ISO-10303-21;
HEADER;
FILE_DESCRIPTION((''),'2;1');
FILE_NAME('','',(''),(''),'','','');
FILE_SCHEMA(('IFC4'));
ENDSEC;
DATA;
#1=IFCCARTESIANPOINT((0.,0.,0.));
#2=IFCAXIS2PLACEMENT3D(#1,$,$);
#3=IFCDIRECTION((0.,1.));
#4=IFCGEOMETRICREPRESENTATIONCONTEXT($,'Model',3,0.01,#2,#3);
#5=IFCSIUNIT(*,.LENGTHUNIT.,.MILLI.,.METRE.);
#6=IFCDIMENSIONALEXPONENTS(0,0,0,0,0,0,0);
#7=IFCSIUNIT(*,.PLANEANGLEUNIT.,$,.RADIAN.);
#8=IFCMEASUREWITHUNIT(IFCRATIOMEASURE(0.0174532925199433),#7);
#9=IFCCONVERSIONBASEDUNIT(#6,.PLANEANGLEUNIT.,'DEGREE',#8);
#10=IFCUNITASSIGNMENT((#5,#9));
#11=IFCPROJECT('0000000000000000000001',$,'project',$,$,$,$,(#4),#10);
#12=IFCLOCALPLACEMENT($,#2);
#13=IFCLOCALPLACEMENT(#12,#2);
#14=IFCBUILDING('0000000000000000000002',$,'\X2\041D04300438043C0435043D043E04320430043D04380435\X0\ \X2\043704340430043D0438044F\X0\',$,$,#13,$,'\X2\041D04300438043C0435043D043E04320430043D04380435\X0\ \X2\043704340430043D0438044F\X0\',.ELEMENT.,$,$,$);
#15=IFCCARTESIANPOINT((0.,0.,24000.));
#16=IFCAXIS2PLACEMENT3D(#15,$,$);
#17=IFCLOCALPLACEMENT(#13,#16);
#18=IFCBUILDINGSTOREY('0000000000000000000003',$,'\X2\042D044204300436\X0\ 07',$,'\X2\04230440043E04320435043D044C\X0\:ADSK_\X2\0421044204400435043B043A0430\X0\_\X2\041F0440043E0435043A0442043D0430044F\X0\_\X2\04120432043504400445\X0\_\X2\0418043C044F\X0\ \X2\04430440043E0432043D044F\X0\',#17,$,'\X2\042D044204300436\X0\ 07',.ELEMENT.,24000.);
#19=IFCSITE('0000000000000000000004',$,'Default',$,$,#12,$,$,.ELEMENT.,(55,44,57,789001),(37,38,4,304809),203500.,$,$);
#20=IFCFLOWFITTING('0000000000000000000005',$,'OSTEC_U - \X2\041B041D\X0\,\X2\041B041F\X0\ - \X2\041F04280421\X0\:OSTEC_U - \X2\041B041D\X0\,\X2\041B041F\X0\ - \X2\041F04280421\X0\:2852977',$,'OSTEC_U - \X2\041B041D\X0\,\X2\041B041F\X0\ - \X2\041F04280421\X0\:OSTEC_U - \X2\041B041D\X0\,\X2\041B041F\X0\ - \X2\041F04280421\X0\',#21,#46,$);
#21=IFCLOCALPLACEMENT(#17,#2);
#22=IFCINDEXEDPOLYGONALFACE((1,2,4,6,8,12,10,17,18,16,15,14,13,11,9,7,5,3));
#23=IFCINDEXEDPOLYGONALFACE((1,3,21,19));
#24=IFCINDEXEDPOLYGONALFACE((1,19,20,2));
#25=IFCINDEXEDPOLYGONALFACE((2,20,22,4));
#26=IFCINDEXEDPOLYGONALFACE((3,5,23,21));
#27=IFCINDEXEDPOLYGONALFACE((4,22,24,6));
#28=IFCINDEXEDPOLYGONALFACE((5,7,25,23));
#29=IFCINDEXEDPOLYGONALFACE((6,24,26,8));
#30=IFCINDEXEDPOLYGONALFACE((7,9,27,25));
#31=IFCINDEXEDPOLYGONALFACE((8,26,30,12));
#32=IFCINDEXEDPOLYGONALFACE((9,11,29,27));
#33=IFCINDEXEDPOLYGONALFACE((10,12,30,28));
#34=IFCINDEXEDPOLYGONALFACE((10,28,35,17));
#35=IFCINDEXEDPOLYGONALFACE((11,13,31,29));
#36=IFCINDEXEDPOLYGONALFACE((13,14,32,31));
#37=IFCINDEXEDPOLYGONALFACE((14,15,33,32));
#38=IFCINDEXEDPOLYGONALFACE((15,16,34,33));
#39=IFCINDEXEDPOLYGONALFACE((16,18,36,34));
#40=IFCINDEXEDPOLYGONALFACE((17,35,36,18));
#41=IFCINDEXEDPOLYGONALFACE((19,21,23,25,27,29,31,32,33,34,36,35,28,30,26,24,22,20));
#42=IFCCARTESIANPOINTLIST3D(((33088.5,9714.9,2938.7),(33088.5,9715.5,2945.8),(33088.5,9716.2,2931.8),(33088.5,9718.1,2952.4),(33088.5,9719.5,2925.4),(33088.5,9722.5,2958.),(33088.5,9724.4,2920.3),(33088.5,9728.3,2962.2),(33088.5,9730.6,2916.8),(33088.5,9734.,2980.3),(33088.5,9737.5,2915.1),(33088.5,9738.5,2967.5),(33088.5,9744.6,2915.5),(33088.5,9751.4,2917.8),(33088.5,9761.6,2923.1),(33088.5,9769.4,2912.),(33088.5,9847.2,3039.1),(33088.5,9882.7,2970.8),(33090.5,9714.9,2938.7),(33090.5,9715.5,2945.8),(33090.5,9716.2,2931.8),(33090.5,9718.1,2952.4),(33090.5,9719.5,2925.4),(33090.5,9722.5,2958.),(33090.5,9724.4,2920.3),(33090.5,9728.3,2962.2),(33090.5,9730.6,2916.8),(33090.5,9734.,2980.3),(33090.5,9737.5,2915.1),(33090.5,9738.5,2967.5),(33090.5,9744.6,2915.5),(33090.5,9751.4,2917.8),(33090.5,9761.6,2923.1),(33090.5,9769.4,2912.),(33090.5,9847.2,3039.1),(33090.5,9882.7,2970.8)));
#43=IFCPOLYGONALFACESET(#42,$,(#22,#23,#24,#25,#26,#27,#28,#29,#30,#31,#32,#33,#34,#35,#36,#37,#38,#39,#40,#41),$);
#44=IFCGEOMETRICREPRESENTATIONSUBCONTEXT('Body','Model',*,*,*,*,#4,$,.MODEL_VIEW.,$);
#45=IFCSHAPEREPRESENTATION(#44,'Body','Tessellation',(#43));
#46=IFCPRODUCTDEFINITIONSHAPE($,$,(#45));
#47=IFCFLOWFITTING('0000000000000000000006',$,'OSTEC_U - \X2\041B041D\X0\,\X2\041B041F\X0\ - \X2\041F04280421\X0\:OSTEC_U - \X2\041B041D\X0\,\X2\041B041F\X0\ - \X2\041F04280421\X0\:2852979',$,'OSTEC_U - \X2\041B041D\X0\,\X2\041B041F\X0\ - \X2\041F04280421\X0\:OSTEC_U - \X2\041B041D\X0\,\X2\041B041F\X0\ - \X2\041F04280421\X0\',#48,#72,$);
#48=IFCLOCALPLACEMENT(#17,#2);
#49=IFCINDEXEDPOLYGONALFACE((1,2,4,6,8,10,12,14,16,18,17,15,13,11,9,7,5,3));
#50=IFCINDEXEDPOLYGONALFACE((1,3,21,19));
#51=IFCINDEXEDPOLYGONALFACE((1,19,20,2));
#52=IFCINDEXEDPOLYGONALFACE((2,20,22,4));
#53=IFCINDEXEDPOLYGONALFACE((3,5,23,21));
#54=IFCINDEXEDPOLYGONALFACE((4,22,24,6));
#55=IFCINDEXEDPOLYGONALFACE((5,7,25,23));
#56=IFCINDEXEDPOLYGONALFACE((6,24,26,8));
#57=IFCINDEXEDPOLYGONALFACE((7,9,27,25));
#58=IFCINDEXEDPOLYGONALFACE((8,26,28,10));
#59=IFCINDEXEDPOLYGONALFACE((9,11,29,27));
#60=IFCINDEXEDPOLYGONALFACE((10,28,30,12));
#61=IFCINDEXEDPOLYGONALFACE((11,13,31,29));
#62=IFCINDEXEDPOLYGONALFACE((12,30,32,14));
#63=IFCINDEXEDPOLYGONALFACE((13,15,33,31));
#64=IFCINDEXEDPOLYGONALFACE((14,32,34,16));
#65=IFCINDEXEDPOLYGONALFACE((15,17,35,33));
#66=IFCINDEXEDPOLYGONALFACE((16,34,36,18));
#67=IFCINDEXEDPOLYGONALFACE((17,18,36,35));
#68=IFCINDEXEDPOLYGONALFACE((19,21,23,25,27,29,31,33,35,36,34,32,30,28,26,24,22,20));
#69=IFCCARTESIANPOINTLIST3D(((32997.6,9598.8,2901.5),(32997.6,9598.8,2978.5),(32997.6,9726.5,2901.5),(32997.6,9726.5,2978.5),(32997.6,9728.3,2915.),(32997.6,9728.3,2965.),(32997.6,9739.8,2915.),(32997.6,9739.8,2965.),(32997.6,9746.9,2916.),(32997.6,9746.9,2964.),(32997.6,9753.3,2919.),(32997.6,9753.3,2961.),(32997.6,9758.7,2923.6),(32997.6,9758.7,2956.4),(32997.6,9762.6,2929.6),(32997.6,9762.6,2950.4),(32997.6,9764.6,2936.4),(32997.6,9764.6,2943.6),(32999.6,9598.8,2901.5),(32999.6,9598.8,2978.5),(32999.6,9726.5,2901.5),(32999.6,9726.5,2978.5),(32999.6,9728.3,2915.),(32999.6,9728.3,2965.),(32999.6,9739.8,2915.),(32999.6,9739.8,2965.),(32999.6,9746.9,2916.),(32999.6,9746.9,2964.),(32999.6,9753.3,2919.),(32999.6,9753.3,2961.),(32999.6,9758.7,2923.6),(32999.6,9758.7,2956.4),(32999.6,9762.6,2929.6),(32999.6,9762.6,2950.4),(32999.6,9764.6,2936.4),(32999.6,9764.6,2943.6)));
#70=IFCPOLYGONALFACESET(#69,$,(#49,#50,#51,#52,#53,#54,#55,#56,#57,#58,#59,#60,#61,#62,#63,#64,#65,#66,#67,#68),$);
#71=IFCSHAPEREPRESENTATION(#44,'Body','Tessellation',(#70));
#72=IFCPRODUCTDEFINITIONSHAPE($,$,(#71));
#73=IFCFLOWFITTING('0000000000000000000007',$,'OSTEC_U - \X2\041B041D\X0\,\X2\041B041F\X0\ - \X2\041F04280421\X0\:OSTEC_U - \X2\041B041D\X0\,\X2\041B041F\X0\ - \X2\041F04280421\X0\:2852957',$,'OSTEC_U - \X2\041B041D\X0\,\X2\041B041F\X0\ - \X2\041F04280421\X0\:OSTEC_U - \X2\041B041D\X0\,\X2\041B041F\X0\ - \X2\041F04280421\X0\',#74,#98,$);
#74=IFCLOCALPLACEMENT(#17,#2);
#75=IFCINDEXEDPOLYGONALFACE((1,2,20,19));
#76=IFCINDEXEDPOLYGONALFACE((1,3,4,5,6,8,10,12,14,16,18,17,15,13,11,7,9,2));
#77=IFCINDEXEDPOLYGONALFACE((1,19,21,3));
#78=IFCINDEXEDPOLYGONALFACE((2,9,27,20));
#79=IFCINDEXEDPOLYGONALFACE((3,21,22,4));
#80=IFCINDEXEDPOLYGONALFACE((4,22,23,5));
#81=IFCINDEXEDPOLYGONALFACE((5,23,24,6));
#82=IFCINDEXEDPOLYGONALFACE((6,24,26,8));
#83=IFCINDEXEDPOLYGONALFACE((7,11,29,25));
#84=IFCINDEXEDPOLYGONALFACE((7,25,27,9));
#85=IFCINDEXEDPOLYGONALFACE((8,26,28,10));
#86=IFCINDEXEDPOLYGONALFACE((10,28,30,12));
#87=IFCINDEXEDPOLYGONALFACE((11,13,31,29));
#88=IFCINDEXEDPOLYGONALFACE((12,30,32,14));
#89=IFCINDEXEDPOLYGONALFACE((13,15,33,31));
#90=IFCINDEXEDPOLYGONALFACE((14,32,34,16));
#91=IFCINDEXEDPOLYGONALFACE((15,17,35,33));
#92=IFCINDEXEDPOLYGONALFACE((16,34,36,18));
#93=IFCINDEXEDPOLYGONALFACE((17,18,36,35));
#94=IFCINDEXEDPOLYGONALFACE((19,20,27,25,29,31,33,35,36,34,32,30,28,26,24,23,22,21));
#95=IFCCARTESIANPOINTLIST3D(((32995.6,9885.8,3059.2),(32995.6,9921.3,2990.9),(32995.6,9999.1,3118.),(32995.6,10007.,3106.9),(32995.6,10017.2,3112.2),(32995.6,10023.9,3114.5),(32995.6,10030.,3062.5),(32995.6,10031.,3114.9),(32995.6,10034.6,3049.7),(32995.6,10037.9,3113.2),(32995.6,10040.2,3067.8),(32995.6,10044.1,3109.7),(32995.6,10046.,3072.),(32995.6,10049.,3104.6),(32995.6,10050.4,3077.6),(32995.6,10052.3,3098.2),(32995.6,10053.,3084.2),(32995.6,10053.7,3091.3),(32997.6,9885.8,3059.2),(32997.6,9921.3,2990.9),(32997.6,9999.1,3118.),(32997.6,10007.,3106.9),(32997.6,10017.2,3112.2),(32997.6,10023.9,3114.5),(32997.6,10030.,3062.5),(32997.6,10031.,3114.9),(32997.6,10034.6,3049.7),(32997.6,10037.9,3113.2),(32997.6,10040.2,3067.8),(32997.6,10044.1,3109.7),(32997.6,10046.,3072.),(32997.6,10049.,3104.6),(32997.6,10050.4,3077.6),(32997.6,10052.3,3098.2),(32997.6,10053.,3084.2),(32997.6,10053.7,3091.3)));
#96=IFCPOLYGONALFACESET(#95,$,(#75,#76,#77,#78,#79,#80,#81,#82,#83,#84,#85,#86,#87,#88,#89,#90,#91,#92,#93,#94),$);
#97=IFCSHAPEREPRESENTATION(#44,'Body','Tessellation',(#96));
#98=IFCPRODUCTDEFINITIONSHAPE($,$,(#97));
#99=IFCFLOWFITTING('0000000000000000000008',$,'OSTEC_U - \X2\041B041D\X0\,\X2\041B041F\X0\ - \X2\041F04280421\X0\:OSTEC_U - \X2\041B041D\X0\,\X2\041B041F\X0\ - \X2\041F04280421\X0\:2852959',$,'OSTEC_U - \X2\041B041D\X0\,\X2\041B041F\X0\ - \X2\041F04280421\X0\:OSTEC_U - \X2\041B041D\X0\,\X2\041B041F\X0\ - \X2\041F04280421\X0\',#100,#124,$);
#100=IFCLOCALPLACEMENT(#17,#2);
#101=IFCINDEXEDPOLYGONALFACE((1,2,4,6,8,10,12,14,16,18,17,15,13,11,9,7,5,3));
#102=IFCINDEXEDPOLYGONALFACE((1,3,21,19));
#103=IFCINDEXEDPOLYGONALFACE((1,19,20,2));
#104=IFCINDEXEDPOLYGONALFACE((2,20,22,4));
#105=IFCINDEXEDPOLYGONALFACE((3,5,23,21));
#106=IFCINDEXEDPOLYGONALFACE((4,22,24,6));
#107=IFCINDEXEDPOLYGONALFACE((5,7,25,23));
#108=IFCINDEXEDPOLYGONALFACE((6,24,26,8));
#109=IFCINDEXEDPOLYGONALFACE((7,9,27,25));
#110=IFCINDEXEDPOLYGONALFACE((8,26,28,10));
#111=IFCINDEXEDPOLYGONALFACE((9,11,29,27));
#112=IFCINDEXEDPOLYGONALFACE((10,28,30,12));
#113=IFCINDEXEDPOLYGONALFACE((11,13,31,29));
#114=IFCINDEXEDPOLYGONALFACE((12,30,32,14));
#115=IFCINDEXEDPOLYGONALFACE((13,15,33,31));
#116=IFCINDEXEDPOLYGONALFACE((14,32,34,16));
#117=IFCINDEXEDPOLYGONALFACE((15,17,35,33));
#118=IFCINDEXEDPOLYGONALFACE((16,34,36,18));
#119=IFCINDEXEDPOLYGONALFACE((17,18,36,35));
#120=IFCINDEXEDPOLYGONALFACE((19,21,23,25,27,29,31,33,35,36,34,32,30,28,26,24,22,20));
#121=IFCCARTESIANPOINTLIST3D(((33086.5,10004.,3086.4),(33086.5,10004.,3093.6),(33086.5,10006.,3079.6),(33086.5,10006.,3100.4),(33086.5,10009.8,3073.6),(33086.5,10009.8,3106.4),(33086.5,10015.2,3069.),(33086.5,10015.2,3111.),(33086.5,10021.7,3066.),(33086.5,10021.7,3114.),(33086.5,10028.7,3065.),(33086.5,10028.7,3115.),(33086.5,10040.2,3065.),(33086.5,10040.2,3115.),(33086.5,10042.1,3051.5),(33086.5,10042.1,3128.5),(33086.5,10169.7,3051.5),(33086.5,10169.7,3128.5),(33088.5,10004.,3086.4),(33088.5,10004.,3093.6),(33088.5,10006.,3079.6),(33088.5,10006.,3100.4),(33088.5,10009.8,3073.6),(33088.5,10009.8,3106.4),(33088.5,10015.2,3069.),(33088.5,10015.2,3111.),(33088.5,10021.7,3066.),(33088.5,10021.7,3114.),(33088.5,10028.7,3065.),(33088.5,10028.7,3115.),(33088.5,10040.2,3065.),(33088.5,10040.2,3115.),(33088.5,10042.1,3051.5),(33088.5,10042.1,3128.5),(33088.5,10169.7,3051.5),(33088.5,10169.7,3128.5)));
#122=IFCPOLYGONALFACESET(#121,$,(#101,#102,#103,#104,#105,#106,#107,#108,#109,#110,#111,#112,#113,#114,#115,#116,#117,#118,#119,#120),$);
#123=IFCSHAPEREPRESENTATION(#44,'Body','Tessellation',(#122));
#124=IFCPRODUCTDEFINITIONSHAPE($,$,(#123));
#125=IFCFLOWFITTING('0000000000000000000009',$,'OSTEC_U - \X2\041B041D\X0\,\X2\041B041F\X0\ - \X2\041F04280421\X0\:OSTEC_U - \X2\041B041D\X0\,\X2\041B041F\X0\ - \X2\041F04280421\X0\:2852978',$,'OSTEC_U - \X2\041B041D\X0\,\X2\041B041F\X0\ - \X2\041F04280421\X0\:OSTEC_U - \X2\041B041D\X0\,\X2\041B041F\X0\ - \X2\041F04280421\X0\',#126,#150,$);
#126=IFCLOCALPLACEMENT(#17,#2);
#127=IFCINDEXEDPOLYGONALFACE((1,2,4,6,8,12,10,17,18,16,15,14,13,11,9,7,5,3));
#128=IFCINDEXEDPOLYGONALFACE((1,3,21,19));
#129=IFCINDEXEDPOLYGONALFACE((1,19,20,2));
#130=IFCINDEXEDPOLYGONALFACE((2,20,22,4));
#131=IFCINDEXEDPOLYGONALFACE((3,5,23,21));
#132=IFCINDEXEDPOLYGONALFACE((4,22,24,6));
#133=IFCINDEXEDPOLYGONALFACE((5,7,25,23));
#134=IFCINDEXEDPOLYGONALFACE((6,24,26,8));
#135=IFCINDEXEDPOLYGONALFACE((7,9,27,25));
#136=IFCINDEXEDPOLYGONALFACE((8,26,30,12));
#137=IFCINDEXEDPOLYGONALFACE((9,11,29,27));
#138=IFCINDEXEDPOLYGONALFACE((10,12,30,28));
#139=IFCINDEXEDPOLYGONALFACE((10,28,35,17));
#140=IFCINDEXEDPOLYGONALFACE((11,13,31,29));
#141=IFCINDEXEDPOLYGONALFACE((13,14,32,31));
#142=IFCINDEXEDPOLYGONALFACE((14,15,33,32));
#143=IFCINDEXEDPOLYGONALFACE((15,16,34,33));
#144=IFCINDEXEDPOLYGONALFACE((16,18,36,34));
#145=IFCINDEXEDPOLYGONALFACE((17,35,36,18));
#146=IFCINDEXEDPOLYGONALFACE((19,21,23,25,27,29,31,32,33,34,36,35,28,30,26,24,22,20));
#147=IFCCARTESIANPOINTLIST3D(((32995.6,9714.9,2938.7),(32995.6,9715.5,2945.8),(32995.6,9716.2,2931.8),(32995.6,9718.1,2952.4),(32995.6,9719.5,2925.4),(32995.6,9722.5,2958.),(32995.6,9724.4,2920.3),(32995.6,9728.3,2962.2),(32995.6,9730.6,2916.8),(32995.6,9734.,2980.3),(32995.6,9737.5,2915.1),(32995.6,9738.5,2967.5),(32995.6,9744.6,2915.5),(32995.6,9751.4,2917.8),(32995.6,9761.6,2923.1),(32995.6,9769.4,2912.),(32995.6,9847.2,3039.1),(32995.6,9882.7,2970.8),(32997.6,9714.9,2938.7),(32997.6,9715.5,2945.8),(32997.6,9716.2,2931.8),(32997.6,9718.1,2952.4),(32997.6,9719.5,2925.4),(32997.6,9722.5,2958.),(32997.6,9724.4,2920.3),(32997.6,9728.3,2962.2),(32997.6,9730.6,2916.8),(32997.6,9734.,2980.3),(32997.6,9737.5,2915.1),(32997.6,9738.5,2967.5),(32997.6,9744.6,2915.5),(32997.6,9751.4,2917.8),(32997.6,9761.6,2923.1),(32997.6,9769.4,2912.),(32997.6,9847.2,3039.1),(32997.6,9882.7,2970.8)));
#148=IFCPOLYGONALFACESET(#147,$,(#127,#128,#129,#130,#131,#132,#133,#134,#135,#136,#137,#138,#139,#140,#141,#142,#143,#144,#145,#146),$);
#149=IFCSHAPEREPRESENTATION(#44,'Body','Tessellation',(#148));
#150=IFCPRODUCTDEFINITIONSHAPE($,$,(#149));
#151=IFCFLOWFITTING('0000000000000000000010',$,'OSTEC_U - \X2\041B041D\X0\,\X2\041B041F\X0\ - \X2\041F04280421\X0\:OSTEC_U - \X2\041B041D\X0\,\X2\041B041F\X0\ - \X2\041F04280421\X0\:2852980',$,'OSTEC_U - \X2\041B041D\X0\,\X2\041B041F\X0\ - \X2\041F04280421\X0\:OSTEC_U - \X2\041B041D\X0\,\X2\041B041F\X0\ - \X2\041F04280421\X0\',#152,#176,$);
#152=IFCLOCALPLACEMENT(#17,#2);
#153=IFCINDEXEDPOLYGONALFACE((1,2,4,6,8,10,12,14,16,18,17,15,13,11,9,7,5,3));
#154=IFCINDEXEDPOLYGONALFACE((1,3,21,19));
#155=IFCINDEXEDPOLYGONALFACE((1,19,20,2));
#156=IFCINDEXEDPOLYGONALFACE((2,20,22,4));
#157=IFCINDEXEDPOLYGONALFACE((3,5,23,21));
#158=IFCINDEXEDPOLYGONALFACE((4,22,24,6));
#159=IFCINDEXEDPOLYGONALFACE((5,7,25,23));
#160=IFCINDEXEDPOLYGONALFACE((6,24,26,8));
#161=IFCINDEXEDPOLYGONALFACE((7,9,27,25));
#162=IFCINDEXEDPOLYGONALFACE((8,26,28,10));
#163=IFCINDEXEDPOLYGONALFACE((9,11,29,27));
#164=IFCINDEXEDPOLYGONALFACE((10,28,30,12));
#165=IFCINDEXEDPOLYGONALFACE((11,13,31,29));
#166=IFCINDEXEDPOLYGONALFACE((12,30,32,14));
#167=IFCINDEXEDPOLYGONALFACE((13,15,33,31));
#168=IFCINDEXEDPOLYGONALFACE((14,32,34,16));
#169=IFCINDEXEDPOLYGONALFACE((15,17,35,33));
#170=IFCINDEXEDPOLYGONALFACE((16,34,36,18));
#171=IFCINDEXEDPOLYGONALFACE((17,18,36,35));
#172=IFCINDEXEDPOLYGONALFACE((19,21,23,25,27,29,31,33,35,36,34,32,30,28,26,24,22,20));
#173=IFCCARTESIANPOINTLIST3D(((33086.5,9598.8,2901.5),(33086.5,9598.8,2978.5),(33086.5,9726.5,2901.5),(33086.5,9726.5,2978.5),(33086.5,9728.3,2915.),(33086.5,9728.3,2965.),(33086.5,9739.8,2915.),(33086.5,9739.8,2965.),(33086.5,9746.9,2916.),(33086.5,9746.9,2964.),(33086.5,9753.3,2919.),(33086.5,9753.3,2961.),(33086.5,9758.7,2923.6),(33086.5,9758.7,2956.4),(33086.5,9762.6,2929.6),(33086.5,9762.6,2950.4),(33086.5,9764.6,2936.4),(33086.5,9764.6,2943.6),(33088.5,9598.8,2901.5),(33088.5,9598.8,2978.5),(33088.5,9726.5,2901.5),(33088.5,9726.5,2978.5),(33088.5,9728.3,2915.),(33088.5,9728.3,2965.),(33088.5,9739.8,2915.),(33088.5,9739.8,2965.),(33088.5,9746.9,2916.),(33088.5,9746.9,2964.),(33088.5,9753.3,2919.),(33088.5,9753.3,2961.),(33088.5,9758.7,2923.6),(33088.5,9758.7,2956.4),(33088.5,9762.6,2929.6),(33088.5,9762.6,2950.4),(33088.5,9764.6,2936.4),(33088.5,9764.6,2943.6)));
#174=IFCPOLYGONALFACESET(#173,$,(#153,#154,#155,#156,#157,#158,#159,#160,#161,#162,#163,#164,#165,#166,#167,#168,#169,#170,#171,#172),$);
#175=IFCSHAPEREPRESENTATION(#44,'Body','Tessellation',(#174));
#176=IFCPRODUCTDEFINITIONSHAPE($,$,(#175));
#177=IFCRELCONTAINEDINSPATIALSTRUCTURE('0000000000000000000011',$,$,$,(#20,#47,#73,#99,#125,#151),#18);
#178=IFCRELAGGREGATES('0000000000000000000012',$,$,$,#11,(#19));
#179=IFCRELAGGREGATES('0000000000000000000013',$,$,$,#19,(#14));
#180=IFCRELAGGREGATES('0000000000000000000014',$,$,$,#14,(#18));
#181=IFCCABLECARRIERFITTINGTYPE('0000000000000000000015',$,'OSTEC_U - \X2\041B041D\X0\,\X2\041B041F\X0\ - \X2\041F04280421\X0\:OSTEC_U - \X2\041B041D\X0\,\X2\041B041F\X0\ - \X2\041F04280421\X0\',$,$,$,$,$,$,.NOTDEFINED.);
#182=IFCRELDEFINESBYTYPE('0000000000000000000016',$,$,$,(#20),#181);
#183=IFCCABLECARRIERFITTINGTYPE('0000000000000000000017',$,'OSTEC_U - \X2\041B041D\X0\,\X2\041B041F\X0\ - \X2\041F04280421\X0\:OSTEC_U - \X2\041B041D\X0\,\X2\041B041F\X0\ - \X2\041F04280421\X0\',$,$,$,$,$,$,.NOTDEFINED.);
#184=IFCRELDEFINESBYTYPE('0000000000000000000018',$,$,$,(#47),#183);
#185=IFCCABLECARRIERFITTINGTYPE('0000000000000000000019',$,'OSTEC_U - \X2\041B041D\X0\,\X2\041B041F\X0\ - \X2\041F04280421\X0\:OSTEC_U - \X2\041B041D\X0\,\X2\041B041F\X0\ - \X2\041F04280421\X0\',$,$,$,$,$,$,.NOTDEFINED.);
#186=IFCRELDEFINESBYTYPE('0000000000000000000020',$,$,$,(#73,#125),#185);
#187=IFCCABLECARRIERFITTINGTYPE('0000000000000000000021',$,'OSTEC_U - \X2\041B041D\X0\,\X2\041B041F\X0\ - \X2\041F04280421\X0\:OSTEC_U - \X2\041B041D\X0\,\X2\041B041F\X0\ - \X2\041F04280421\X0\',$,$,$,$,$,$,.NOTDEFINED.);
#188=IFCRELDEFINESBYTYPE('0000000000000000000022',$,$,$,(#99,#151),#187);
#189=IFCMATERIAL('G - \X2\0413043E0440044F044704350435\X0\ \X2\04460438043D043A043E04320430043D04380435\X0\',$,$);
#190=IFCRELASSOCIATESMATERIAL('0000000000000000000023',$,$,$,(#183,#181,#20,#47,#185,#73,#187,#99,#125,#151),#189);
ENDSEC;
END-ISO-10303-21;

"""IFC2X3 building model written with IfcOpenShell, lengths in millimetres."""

from ifc_helpers import new_model, entity, si_unit, converted_unit, direction, frame, frame_2d, origin, place, context, subcontext, project, spatial, polyline, circle_curve, parameter, trimmed, segment, composite_curve, outline, extrude, source, transform, mapped, material, type_object, type_shapes, element, save


model = new_model("IFC2X3")

# Units and contexts
model_context = context("Model", 3, precision=0.01, world=origin(), true_north=direction((0.0, 1.0)))
body_context = subcontext(model_context, "Body", "Model", "MODEL_VIEW")
ifc_project = project(units=[si_unit("LENGTHUNIT", "METRE", prefix="MILLI"), converted_unit("PLANEANGLEUNIT", "DEGREE", entity("IfcRatioMeasure", 0.0174532925199433), si_unit("PLANEANGLEUNIT", "RADIAN"), dimensions=[0, 0, 0, 0, 0, 0, 0])], contexts=[model_context])

# Site, building, storey
site_placement = place(None, origin())
site = spatial("IfcSite", under=ifc_project, at=site_placement, Name="Default", CompositionType="ELEMENT", RefLatitude=(55, 44, 57, 789001), RefLongitude=(37, 38, 4, 304809), RefElevation=203500.0)
building_placement = place(site_placement, origin())
building = spatial("IfcBuilding", under=site, at=building_placement, Name="Наименование здания", LongName="Наименование здания", CompositionType="ELEMENT")
storey_placement = place(building_placement, frame((0.0, 0.0, 24000.0)))
storey = spatial("IfcBuildingStorey", under=building, at=storey_placement, Name="Этаж 07", ObjectType="Уровень:ADSK_Стрелка_Проектная_Вверх_Имя уровня", LongName="Этаж 07", CompositionType="ELEMENT", Elevation=24000.0)

# Flow fittings
ifc_material_1 = material(Name="G - Горячее цинкование")
cable_carrier_fitting_type_1 = type_object("IfcCableCarrierFittingType", Name="OSTEC_U - ЛН,ЛП - ПШС:OSTEC_U - ЛН,ЛП - ПШС", PredefinedType="NOTDEFINED", material=ifc_material_1)
shared_shape_1 = source(origin(), body_context, "Body", "SweptSolid", [
    extrude(outline(composite_curve([segment(trimmed(circle_curve(frame_2d((-41.5, 0.0), x_axis=(1.0, 0.0)), 25.0), [parameter(90.0)], [parameter(270.0)], True, "PARAMETER"), True, "CONTINUOUS"), segment(polyline([(-41.5, -25.0), (-30.0, -25.0)]), True, "CONTINUOUS"), segment(polyline([(-30.0, -25.0), (-28.1, -38.5)]), True, "CONTINUOUS"), segment(polyline([(-28.1, -38.5), (99.5, -38.5)]), True, "CONTINUOUS"), segment(polyline([(99.5, -38.5), (99.5, 38.5)]), True, "CONTINUOUS"), segment(polyline([(99.5, 38.5), (-28.1, 38.5)]), True, "CONTINUOUS"), segment(polyline([(-28.1, 38.5), (-30.0, 25.0)]), True, "CONTINUOUS"), segment(polyline([(-30.0, 25.0), (-41.5, 25.0)]), True, "CONTINUOUS")], self_intersect=False)), frame((41.5, 0.0, 0.0), z_axis=(0.0, 0.0, -1.0), x_axis=(1.0, 0.0, 0.0)), (0.0, 0.0, -1.0), 2.0),
])
type_shapes(cable_carrier_fitting_type_1, [shared_shape_1])
cable_carrier_fitting_type_2 = type_object("IfcCableCarrierFittingType", Name="OSTEC_U - ЛН,ЛП - ПШС:OSTEC_U - ЛН,ЛП - ПШС", PredefinedType="NOTDEFINED", material=ifc_material_1)
type_shapes(cable_carrier_fitting_type_2, [shared_shape_1])
flow_fitting_1_placement = place(storey_placement, frame((33088.5, 9739.8, 2940.0), z_axis=(1.0, 0.0, 0.0), x_axis=(0.0, 0.887491, 0.460826)))
element("IfcFlowFitting", 1, at=flow_fitting_1_placement, inside=storey, type_object=cable_carrier_fitting_type_2, material=ifc_material_1, Name="OSTEC_U - ЛН,ЛП - ПШС:OSTEC_U - ЛН,ЛП - ПШС:2852977", ObjectType="OSTEC_U - ЛН,ЛП - ПШС:OSTEC_U - ЛН,ЛП - ПШС", context=body_context, shape_type="MappedRepresentation", body=[
    mapped(shared_shape_1, transform((0.0, 0.0, 0.0), scale=1.0)),
])
flow_fitting_2_placement = place(storey_placement, frame((32999.6, 9739.8, 2940.0), z_axis=(-1.0, 0.0, 0.0), x_axis=(0.0, -1.0, 0.0)))
element("IfcFlowFitting", 2, at=flow_fitting_2_placement, inside=storey, type_object=cable_carrier_fitting_type_1, material=ifc_material_1, Name="OSTEC_U - ЛН,ЛП - ПШС:OSTEC_U - ЛН,ЛП - ПШС:2852979", ObjectType="OSTEC_U - ЛН,ЛП - ПШС:OSTEC_U - ЛН,ЛП - ПШС", context=body_context, shape_type="MappedRepresentation", body=[
    mapped(shared_shape_1, transform((0.0, 0.0, 0.0), scale=1.0)),
])
cable_carrier_fitting_type_3 = type_object("IfcCableCarrierFittingType", Name="OSTEC_U - ЛН,ЛП - ПШС:OSTEC_U - ЛН,ЛП - ПШС", PredefinedType="NOTDEFINED", material=ifc_material_1)
shared_shape_2 = source(origin(), body_context, "Body", "SweptSolid", [
    extrude(outline(composite_curve([segment(trimmed(circle_curve(frame_2d((-41.5, 0.0), x_axis=(1.0, 0.0)), 25.0), [parameter(90.0)], [parameter(270.0)], True, "PARAMETER"), True, "CONTINUOUS"), segment(polyline([(-41.5, -25.0), (-30.0, -25.0)]), True, "CONTINUOUS"), segment(polyline([(-30.0, -25.0), (-28.1, -38.5)]), True, "CONTINUOUS"), segment(polyline([(-28.1, -38.5), (99.5, -38.5)]), True, "CONTINUOUS"), segment(polyline([(99.5, -38.5), (99.5, 38.5)]), True, "CONTINUOUS"), segment(polyline([(99.5, 38.5), (-28.1, 38.5)]), True, "CONTINUOUS"), segment(polyline([(-28.1, 38.5), (-30.0, 25.0)]), True, "CONTINUOUS"), segment(polyline([(-30.0, 25.0), (-41.5, 25.0)]), True, "CONTINUOUS")], self_intersect=False)), frame((41.5, 0.0, 0.0)), (0.0, 0.0, 1.0), 2.0),
])
type_shapes(cable_carrier_fitting_type_3, [shared_shape_2])
flow_fitting_3_placement = place(storey_placement, frame((32997.6, 10028.7, 3090.0), z_axis=(-1.0, 0.0, 0.0), x_axis=(0.0, -0.887491, -0.460826)))
element("IfcFlowFitting", 3, at=flow_fitting_3_placement, inside=storey, type_object=cable_carrier_fitting_type_3, material=ifc_material_1, Name="OSTEC_U - ЛН,ЛП - ПШС:OSTEC_U - ЛН,ЛП - ПШС:2852957", ObjectType="OSTEC_U - ЛН,ЛП - ПШС:OSTEC_U - ЛН,ЛП - ПШС", context=body_context, shape_type="MappedRepresentation", body=[
    mapped(shared_shape_2, transform((0.0, 0.0, 0.0), scale=1.0)),
])
cable_carrier_fitting_type_4 = type_object("IfcCableCarrierFittingType", Name="OSTEC_U - ЛН,ЛП - ПШС:OSTEC_U - ЛН,ЛП - ПШС", PredefinedType="NOTDEFINED", material=ifc_material_1)
type_shapes(cable_carrier_fitting_type_4, [shared_shape_2])
flow_fitting_4_placement = place(storey_placement, frame((33086.5, 10028.7, 3090.0), z_axis=(1.0, 0.0, 0.0), x_axis=(0.0, 1.0, 0.0)))
element("IfcFlowFitting", 4, at=flow_fitting_4_placement, inside=storey, type_object=cable_carrier_fitting_type_4, material=ifc_material_1, Name="OSTEC_U - ЛН,ЛП - ПШС:OSTEC_U - ЛН,ЛП - ПШС:2852959", ObjectType="OSTEC_U - ЛН,ЛП - ПШС:OSTEC_U - ЛН,ЛП - ПШС", context=body_context, shape_type="MappedRepresentation", body=[
    mapped(shared_shape_2, transform((0.0, 0.0, 0.0), scale=1.0)),
])
flow_fitting_5_placement = place(storey_placement, frame((32997.6, 9739.8, 2940.0), z_axis=(-1.0, 0.0, 0.0), x_axis=(0.0, 0.887491, 0.460826)))
element("IfcFlowFitting", 5, at=flow_fitting_5_placement, inside=storey, type_object=cable_carrier_fitting_type_3, material=ifc_material_1, Name="OSTEC_U - ЛН,ЛП - ПШС:OSTEC_U - ЛН,ЛП - ПШС:2852978", ObjectType="OSTEC_U - ЛН,ЛП - ПШС:OSTEC_U - ЛН,ЛП - ПШС", context=body_context, shape_type="MappedRepresentation", body=[
    mapped(shared_shape_2, transform((0.0, 0.0, 0.0), scale=1.0)),
])
flow_fitting_6_placement = place(storey_placement, frame((33086.5, 9739.8, 2940.0), z_axis=(1.0, 0.0, 0.0), x_axis=(0.0, -1.0, 0.0)))
element("IfcFlowFitting", 6, at=flow_fitting_6_placement, inside=storey, type_object=cable_carrier_fitting_type_4, material=ifc_material_1, Name="OSTEC_U - ЛН,ЛП - ПШС:OSTEC_U - ЛН,ЛП - ПШС:2852980", ObjectType="OSTEC_U - ЛН,ЛП - ПШС:OSTEC_U - ЛН,ЛП - ПШС", context=body_context, shape_type="MappedRepresentation", body=[
    mapped(shared_shape_2, transform((0.0, 0.0, 0.0), scale=1.0)),
])

save(model, "model.ifc")
